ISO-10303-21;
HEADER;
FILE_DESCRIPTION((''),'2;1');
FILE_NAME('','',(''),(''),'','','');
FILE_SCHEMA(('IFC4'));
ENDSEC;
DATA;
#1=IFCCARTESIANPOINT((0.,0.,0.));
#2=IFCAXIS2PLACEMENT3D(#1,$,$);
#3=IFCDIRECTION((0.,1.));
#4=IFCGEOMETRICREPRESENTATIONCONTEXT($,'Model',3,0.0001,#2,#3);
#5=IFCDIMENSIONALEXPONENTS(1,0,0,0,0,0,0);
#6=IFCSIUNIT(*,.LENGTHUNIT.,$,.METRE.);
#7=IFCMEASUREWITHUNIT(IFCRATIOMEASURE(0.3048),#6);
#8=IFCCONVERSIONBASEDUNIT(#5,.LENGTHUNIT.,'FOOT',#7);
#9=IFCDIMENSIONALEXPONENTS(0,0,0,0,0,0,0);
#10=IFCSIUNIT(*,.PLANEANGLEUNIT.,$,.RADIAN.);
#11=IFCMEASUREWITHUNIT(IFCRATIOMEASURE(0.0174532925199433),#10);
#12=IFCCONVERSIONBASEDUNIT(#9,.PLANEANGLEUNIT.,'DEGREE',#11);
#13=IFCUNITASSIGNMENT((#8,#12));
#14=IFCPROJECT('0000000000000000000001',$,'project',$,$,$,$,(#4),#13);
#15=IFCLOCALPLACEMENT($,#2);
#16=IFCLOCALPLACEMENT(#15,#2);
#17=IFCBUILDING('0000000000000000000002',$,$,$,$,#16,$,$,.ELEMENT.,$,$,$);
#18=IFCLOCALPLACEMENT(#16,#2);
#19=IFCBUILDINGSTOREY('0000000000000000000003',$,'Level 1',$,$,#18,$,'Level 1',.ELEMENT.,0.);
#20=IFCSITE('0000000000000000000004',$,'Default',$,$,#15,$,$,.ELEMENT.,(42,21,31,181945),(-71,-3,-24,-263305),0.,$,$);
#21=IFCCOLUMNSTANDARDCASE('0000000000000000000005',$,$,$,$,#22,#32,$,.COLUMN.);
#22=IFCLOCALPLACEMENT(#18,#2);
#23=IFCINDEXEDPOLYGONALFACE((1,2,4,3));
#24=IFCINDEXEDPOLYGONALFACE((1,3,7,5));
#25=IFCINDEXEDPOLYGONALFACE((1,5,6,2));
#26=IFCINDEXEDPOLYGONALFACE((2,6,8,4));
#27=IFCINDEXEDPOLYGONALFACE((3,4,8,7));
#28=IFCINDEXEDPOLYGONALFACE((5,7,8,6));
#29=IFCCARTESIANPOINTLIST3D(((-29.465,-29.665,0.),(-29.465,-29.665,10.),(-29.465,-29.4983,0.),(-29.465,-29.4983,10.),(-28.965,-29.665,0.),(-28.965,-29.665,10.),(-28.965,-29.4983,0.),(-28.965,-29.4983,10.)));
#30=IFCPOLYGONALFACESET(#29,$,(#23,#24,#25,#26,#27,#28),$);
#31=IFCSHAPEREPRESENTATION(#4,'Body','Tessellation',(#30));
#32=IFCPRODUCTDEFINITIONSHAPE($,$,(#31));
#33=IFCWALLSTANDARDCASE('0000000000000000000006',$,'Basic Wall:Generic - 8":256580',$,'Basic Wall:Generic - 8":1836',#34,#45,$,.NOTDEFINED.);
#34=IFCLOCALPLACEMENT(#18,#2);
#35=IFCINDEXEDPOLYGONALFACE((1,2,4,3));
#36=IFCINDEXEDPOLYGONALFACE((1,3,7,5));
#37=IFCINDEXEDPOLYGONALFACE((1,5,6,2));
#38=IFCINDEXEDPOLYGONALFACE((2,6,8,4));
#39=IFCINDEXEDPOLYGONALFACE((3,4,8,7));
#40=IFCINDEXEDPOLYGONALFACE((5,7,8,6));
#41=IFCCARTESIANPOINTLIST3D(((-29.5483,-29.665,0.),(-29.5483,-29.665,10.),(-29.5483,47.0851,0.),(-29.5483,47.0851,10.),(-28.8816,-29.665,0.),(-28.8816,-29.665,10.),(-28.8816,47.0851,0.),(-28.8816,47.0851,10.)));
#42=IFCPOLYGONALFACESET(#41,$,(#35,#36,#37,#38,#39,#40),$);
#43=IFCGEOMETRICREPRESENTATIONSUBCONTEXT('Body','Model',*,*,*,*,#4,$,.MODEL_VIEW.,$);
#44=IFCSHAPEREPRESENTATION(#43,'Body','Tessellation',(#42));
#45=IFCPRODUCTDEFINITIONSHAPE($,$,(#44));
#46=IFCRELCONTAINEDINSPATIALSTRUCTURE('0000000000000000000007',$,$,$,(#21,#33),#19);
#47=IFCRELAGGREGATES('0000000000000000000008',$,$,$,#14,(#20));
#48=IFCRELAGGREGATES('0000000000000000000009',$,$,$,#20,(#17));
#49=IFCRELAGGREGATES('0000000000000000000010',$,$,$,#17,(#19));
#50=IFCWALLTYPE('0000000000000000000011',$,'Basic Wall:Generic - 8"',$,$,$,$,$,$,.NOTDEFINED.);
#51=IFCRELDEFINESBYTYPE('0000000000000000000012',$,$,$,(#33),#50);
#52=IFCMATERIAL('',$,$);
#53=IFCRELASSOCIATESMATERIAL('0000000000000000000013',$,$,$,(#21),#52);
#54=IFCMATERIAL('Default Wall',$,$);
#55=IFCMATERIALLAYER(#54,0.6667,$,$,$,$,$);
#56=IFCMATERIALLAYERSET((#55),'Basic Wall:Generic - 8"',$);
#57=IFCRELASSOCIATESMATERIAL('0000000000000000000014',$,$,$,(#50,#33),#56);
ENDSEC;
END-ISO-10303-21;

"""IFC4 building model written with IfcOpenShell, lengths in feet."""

from ifc_helpers import new_model, entity, si_unit, converted_unit, direction, frame, frame_2d, origin, place, context, subcontext, project, spatial, rectangle, extrude, material, layer, layer_set, layer_usage, type_object, element, save


model = new_model("IFC4")

# Units and contexts
model_context = context("Model", 3, precision=0.0001, world=origin(), true_north=direction((0.0, 1.0)))
body_context = subcontext(model_context, "Body", "Model", "MODEL_VIEW")
ifc_project = project(units=[converted_unit("LENGTHUNIT", "FOOT", entity("IfcRatioMeasure", 0.3048), si_unit("LENGTHUNIT", "METRE"), dimensions=[1, 0, 0, 0, 0, 0, 0]), converted_unit("PLANEANGLEUNIT", "DEGREE", entity("IfcRatioMeasure", 0.0174532925199433), si_unit("PLANEANGLEUNIT", "RADIAN"), dimensions=[0, 0, 0, 0, 0, 0, 0])], contexts=[model_context])

# Site, building, storey
site_placement = place(None, origin())
site = spatial("IfcSite", under=ifc_project, at=site_placement, Name="Default", CompositionType="ELEMENT", RefLatitude=(42, 21, 31, 181945), RefLongitude=(-71, -3, -24, -263305), RefElevation=0.0)
building_placement = place(site_placement, origin())
building = spatial("IfcBuilding", under=site, at=building_placement, CompositionType="ELEMENT")
storey_placement = place(building_placement, origin())
storey = spatial("IfcBuildingStorey", under=building, at=storey_placement, Name="Level 1", LongName="Level 1", CompositionType="ELEMENT", Elevation=0.0)

# Column
ifc_material_1 = material(Name="")
wall_placement = place(storey_placement, frame((-29.215, -29.665, 0.0), z_axis=(0.0, 0.0, 1.0), x_axis=(0.0, 1.0, 0.0)))
for number, where, z_axis, x_axis in (
    (1, (0.0833, 0.0, 0.0), (0.0, 0.0, 1.0), (1.0, 0.0, 0.0)),
):
    element("IfcColumnStandardCase", number, at=place(wall_placement, frame(where, z_axis=z_axis, x_axis=x_axis)), inside=storey, material=ifc_material_1, PredefinedType="COLUMN", context=model_context, shape_type="SweptSolid", body=[
        extrude(rectangle(XDim=0.1667, YDim=0.5), origin(), (0.0, 0.0, 1.0), 10.0),
    ])

# Wall
ifc_material_2 = material(Name="Default Wall")
ifc_layer = layer(ifc_material_2, 0.6667)
ifc_layer_set = layer_set([ifc_layer], Name="Basic Wall:Generic - 8\"")
ifc_layer_usage = layer_usage(ifc_layer_set, "AXIS2", "NEGATIVE", 0.3333)
wall_type = type_object("IfcWallType", Name="Basic Wall:Generic - 8\"", PredefinedType="NOTDEFINED", material=ifc_layer_set)
element("IfcWallStandardCase", 2, at=wall_placement, inside=storey, type_object=wall_type, material=ifc_layer_usage, Name="Basic Wall:Generic - 8\":256580", ObjectType="Basic Wall:Generic - 8\":1836", PredefinedType="NOTDEFINED", context=body_context, shape_type="SweptSolid", body=[
    extrude(rectangle(XDim=76.7501, YDim=0.6667, at=frame_2d((38.375, 0.0), x_axis=(-1.0, 0.0))), origin(), (0.0, 0.0, 1.0), 10.0),
])

save(model, "model.ifc")
